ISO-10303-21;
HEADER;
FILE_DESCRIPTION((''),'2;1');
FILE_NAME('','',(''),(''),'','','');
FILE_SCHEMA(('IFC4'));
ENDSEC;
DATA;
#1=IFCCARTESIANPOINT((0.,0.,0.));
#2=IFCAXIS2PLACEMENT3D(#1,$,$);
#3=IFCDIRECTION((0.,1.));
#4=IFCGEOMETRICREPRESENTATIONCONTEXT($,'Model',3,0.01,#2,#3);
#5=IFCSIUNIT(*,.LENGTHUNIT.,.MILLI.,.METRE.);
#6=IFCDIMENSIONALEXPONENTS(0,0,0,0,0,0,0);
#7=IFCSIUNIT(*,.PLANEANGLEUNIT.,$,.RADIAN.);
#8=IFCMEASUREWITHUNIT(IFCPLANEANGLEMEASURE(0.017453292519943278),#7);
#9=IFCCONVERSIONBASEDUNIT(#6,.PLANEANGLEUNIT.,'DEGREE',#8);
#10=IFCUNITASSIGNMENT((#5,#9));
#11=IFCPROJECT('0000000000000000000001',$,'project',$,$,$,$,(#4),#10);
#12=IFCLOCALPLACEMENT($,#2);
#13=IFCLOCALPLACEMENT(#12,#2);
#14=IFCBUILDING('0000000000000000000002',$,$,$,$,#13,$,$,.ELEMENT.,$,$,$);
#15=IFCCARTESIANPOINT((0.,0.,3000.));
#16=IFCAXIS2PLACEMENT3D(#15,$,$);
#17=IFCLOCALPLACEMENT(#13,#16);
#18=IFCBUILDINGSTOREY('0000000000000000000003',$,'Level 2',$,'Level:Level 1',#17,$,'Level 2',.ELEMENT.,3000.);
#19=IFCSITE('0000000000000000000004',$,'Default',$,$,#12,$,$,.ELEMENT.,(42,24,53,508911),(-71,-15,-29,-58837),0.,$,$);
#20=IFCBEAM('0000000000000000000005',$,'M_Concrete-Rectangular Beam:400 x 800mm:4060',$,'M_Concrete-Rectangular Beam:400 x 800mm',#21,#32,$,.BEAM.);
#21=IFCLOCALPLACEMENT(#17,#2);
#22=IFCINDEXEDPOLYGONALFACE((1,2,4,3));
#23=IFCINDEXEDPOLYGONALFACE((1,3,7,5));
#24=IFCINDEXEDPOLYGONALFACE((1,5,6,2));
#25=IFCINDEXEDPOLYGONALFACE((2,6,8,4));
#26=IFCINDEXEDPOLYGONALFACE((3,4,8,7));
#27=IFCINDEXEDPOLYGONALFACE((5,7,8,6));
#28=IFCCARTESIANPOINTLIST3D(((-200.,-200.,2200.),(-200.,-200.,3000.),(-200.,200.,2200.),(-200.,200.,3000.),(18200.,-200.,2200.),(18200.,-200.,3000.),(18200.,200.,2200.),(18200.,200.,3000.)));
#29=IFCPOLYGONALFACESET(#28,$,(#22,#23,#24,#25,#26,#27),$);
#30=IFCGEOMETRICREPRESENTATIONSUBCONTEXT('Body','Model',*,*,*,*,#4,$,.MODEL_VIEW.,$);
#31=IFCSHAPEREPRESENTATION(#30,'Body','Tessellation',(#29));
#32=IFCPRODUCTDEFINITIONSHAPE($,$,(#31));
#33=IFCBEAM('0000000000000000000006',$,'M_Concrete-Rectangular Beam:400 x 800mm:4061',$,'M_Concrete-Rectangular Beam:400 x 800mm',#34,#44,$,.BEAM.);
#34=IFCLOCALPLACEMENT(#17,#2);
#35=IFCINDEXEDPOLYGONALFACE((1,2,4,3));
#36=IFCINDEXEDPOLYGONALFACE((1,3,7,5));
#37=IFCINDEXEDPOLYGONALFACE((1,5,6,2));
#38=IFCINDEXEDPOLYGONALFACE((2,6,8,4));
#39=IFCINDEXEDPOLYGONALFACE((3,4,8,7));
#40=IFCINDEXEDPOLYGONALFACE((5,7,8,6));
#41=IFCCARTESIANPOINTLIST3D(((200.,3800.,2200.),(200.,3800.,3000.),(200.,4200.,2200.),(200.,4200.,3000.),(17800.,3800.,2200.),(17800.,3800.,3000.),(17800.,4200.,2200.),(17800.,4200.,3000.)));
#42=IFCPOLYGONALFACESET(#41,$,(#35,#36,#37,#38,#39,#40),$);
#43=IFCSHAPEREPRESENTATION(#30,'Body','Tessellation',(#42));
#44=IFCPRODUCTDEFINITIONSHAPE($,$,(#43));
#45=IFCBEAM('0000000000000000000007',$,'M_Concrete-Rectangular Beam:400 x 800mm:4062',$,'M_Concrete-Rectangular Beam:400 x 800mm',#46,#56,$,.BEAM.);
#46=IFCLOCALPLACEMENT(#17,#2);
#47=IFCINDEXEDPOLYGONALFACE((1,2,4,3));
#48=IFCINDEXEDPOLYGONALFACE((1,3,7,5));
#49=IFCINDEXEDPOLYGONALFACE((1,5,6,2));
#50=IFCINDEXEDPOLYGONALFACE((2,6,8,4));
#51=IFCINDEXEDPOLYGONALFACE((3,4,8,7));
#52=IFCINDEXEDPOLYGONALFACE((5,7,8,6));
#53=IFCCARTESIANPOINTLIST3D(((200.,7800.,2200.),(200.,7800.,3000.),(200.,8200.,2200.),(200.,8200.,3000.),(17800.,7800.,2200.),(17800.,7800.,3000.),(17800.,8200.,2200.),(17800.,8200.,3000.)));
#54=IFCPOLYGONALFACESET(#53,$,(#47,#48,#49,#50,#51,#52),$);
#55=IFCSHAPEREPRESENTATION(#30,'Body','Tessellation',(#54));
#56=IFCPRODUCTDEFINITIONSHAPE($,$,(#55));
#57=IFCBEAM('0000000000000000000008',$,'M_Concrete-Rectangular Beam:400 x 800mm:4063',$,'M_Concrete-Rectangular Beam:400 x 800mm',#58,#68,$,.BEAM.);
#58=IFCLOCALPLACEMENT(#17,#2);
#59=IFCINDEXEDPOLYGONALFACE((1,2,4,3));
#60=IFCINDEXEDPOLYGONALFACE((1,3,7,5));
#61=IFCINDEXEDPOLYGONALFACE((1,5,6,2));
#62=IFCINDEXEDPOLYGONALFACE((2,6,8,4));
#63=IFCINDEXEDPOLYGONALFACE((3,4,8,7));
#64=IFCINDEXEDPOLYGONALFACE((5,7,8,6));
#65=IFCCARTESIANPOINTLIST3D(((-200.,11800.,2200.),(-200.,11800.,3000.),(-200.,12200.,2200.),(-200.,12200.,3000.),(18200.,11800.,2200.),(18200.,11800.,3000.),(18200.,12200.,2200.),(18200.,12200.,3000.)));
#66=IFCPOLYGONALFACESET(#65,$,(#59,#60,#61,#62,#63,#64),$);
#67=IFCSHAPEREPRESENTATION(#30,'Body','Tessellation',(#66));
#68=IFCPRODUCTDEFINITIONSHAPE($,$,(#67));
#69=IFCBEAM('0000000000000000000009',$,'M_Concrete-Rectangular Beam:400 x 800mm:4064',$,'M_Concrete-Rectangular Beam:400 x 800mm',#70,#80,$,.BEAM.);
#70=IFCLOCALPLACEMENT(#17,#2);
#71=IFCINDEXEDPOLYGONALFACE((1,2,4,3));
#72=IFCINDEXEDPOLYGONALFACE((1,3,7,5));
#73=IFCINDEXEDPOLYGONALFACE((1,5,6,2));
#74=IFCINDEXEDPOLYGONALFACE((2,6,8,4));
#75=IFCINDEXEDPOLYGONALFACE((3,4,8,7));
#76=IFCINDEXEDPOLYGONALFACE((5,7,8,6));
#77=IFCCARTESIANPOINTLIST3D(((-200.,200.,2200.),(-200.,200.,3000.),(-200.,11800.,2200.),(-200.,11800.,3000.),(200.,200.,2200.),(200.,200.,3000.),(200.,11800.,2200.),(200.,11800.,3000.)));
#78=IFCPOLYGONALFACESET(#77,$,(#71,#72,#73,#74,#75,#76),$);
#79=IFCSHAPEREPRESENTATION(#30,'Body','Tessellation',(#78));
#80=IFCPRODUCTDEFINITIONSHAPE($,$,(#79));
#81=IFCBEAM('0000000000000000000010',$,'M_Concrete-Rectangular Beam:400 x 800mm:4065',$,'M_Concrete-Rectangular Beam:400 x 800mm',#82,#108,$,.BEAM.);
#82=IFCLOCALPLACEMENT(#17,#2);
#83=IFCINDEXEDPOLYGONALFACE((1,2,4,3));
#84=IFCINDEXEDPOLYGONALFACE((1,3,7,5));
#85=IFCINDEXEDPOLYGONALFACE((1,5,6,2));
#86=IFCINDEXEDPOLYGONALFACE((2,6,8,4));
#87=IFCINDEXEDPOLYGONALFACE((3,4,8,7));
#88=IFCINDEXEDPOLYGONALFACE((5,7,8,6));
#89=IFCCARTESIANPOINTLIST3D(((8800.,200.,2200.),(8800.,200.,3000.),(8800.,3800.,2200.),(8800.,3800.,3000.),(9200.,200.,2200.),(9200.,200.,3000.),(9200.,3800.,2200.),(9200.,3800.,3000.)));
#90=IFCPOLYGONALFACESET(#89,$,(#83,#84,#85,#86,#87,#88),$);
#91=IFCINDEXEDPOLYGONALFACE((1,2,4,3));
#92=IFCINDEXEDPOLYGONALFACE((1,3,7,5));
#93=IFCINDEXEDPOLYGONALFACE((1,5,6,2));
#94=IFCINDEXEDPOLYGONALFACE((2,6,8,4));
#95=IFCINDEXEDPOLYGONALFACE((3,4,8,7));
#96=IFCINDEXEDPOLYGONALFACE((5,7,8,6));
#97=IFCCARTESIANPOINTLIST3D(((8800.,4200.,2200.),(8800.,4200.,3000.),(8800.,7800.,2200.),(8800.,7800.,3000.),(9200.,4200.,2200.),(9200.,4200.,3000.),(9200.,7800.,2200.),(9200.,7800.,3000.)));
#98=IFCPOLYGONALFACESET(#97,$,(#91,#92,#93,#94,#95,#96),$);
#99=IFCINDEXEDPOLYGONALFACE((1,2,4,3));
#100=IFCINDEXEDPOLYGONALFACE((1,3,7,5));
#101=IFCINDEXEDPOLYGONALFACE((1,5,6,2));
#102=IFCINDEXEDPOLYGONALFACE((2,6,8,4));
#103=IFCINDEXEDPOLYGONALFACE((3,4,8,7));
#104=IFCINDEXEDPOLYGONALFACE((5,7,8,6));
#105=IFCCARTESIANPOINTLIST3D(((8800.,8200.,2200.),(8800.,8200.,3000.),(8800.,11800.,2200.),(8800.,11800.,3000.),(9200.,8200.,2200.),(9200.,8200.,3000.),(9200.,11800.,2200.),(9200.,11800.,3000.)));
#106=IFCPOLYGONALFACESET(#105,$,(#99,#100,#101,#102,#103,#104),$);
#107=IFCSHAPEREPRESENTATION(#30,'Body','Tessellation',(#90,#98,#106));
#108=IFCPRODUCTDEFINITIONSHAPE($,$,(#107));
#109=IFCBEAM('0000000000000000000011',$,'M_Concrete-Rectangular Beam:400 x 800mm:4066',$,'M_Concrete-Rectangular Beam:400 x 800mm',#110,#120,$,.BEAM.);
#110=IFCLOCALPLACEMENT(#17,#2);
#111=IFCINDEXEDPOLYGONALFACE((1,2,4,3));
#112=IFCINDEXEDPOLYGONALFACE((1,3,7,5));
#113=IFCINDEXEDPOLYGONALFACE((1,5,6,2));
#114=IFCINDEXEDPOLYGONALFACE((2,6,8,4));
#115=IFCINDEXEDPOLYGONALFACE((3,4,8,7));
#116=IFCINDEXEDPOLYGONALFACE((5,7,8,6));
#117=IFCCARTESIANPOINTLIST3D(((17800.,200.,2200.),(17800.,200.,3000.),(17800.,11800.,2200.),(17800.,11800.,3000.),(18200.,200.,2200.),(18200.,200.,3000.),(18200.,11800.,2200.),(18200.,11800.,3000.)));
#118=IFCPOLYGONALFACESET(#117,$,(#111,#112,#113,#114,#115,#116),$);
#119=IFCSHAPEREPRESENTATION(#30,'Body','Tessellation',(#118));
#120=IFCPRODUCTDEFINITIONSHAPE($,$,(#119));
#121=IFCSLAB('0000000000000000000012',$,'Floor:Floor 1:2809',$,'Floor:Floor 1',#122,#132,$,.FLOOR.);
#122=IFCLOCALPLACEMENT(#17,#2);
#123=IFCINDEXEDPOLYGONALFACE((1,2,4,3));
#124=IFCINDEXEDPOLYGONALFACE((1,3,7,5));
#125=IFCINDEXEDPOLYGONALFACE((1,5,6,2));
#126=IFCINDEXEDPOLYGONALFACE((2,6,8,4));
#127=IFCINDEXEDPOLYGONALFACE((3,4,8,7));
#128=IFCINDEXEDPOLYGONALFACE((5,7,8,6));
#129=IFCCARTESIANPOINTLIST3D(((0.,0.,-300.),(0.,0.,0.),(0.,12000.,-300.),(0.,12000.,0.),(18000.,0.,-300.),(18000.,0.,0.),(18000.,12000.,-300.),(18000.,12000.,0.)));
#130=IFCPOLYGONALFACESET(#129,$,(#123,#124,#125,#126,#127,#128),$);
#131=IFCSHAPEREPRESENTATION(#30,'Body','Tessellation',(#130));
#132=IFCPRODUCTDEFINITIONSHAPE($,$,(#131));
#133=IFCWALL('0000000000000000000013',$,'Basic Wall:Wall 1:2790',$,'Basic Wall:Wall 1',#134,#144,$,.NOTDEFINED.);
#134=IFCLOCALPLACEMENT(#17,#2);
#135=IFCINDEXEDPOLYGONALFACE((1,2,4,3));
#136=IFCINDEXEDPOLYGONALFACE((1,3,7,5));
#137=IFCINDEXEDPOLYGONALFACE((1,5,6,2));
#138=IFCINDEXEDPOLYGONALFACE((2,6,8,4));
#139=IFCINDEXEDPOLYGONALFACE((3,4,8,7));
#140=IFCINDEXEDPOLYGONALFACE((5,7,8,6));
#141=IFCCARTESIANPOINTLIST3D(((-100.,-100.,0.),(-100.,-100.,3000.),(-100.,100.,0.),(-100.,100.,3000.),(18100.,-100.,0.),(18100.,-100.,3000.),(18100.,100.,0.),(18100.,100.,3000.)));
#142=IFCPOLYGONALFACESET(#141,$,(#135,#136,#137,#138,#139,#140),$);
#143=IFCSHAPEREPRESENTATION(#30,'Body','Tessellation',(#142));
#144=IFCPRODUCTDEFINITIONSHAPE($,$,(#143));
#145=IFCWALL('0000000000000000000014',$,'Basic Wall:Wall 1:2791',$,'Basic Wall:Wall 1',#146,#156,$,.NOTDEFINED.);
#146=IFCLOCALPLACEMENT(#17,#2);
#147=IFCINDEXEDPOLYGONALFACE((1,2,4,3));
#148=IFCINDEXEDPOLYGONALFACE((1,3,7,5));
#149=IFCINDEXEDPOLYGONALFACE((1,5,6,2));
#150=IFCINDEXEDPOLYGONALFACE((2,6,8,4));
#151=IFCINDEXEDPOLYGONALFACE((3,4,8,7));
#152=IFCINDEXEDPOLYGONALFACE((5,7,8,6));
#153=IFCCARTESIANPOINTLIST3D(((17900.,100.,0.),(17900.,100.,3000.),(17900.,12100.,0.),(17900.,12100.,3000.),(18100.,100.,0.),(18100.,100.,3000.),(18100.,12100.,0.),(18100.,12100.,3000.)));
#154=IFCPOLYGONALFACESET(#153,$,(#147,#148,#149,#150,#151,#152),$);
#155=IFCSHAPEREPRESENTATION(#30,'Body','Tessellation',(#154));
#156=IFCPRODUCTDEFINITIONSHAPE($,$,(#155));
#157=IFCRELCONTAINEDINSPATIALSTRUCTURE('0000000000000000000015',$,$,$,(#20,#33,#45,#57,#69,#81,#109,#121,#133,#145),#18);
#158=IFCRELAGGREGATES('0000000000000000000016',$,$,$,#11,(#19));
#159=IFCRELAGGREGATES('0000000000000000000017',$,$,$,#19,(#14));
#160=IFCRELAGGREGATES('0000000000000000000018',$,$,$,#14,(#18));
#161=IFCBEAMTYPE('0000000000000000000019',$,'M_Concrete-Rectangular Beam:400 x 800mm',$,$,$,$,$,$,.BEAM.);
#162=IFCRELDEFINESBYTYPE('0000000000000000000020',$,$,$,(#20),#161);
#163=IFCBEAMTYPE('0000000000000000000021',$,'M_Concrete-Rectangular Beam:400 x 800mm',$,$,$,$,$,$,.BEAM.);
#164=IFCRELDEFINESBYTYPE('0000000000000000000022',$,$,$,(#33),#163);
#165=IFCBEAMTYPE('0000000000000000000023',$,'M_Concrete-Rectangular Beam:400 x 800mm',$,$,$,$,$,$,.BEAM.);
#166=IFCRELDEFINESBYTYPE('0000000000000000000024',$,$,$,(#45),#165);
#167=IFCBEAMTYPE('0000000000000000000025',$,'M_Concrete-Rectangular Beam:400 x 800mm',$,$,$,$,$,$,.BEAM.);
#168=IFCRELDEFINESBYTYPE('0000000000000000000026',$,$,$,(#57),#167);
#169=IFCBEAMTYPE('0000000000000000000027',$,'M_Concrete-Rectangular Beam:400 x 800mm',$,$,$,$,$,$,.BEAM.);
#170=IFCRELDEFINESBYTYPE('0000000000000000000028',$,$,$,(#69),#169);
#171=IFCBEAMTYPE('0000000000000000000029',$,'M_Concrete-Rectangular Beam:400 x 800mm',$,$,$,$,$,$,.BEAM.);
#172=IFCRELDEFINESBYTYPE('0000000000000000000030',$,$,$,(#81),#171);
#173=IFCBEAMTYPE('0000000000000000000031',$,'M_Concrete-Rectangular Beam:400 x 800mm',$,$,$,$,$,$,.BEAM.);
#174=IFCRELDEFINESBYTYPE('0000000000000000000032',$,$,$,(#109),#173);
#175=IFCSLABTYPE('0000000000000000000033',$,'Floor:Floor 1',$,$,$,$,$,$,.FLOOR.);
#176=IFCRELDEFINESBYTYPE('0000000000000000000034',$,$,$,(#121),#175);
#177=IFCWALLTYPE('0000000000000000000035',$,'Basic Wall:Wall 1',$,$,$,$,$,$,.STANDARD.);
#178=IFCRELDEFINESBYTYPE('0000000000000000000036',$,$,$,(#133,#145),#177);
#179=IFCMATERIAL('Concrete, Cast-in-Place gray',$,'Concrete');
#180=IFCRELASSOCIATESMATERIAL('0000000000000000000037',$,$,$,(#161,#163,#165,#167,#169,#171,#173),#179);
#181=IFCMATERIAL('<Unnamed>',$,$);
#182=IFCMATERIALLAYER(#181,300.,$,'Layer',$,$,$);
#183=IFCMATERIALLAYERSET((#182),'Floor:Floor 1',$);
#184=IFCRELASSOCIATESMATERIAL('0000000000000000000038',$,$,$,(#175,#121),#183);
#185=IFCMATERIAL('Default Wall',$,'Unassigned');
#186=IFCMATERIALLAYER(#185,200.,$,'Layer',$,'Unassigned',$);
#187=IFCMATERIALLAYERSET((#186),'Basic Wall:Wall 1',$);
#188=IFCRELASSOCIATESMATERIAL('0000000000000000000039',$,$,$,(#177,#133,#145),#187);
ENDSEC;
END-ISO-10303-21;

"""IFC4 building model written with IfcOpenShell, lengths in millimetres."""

from ifc_helpers import new_model, entity, si_unit, converted_unit, direction, frame, frame_2d, origin, origin_2d_with_axis, place, context, subcontext, project, spatial, rectangle, extrude, source, transform, mapped, material, layer, layer_set, layer_usage, material_profile, profile_set, type_object, type_shapes, element, save


model = new_model("IFC4")

# Units and contexts
model_context = context("Model", 3, precision=0.01, world=origin(), true_north=direction((0.0, 1.0)))
body_context = subcontext(model_context, "Body", "Model", "MODEL_VIEW")
ifc_project = project(units=[si_unit("LENGTHUNIT", "METRE", prefix="MILLI"), converted_unit("PLANEANGLEUNIT", "DEGREE", entity("IfcPlaneAngleMeasure", 0.017453292519943278), si_unit("PLANEANGLEUNIT", "RADIAN"), dimensions=[0, 0, 0, 0, 0, 0, 0])], contexts=[model_context])

# Site, building, storey
site_placement = place(None, origin())
site = spatial("IfcSite", under=ifc_project, at=site_placement, Name="Default", CompositionType="ELEMENT", RefLatitude=(42, 24, 53, 508911), RefLongitude=(-71, -15, -29, -58837), RefElevation=0.0)
building_placement = place(site_placement, origin())
building = spatial("IfcBuilding", under=site, at=building_placement, CompositionType="ELEMENT")
storey_placement = place(building_placement, frame((0.0, 0.0, 3000.0)))
storey = spatial("IfcBuildingStorey", under=building, at=storey_placement, Name="Level 2", ObjectType="Level:Level 1", LongName="Level 2", CompositionType="ELEMENT", Elevation=3000.0)

# Beams
ifc_material_1 = material(Name="Concrete, Cast-in-Place gray", Category="Concrete")
ifc_material_profile = material_profile(ifc_material_1, rectangle(XDim=800.0, YDim=400.0, at=origin_2d_with_axis()), Name="400 x 800mm")
ifc_profile_set = profile_set([ifc_material_profile], Name="400 x 800mm")
beam_type_1 = type_object("IfcBeamType", Name="M_Concrete-Rectangular Beam:400 x 800mm", PredefinedType="BEAM", material=ifc_profile_set)
shared_shape_1 = source(origin(), body_context, "Body", "SweptSolid", [
    extrude(rectangle(XDim=800.0, YDim=400.0, at=origin_2d_with_axis()), frame((-200.0, 0.0, 5600.0), z_axis=(1.0, 0.0, 0.0), x_axis=(0.0, 0.0, -1.0)), (0.0, 0.0, 1.0), 18400.0),
])
type_shapes(beam_type_1, [shared_shape_1])
beam_1_placement = place(storey_placement, frame((0.0, 0.0, -3000.0)))
element("IfcBeam", 1, at=beam_1_placement, inside=storey, type_object=beam_type_1, Name="M_Concrete-Rectangular Beam:400 x 800mm:4060", ObjectType="M_Concrete-Rectangular Beam:400 x 800mm", PredefinedType="BEAM", context=body_context, shape_type="MappedRepresentation", body=[
    mapped(shared_shape_1, transform((0.0, 0.0, 0.0), scale=1.0)),
])
beam_type_2 = type_object("IfcBeamType", Name="M_Concrete-Rectangular Beam:400 x 800mm", PredefinedType="BEAM", material=ifc_profile_set)
shared_shape_2 = source(origin(), body_context, "Body", "SweptSolid", [
    extrude(rectangle(XDim=800.0, YDim=400.0, at=origin_2d_with_axis()), frame((200.0, 4000.0, 5600.0), z_axis=(1.0, 0.0, 0.0), x_axis=(0.0, 0.0, -1.0)), (0.0, 0.0, 1.0), 17600.0),
])
type_shapes(beam_type_2, [shared_shape_2])
beam_2_placement = place(storey_placement, frame((0.0, 0.0, -3000.0)))
element("IfcBeam", 2, at=beam_2_placement, inside=storey, type_object=beam_type_2, Name="M_Concrete-Rectangular Beam:400 x 800mm:4061", ObjectType="M_Concrete-Rectangular Beam:400 x 800mm", PredefinedType="BEAM", context=body_context, shape_type="MappedRepresentation", body=[
    mapped(shared_shape_2, transform((0.0, 0.0, 0.0), scale=1.0)),
])
beam_type_3 = type_object("IfcBeamType", Name="M_Concrete-Rectangular Beam:400 x 800mm", PredefinedType="BEAM", material=ifc_profile_set)
shared_shape_3 = source(origin(), body_context, "Body", "SweptSolid", [
    extrude(rectangle(XDim=800.0, YDim=400.0, at=frame_2d((0.0, 0.0), x_axis=(1.0, 0.0))), frame((200.0, 8000.0, 5600.0), z_axis=(1.0, 0.0, 0.0), x_axis=(0.0, 0.0, -1.0)), (0.0, 0.0, 1.0), 17600.0),
])
type_shapes(beam_type_3, [shared_shape_3])
beam_3_placement = place(storey_placement, frame((0.0, 0.0, -3000.0)))
element("IfcBeam", 3, at=beam_3_placement, inside=storey, type_object=beam_type_3, Name="M_Concrete-Rectangular Beam:400 x 800mm:4062", ObjectType="M_Concrete-Rectangular Beam:400 x 800mm", PredefinedType="BEAM", context=body_context, shape_type="MappedRepresentation", body=[
    mapped(shared_shape_3, transform((0.0, 0.0, 0.0), scale=1.0)),
])
beam_type_4 = type_object("IfcBeamType", Name="M_Concrete-Rectangular Beam:400 x 800mm", PredefinedType="BEAM", material=ifc_profile_set)
shared_shape_4 = source(origin(), body_context, "Body", "SweptSolid", [
    extrude(rectangle(XDim=800.0, YDim=400.0, at=frame_2d((0.0, 0.0), x_axis=(1.0, 0.0))), frame((-200.0, 12000.0, 5600.0), z_axis=(1.0, 0.0, 0.0), x_axis=(0.0, 0.0, -1.0)), (0.0, 0.0, 1.0), 18400.0),
])
type_shapes(beam_type_4, [shared_shape_4])
beam_4_placement = place(storey_placement, frame((0.0, 0.0, -3000.0)))
element("IfcBeam", 4, at=beam_4_placement, inside=storey, type_object=beam_type_4, Name="M_Concrete-Rectangular Beam:400 x 800mm:4063", ObjectType="M_Concrete-Rectangular Beam:400 x 800mm", PredefinedType="BEAM", context=body_context, shape_type="MappedRepresentation", body=[
    mapped(shared_shape_4, transform((0.0, 0.0, 0.0), scale=1.0)),
])
beam_type_5 = type_object("IfcBeamType", Name="M_Concrete-Rectangular Beam:400 x 800mm", PredefinedType="BEAM", material=ifc_profile_set)
shared_shape_5 = source(origin(), body_context, "Body", "SweptSolid", [
    extrude(rectangle(XDim=800.0, YDim=400.0, at=frame_2d((0.0, 0.0), x_axis=(0.0, 1.0))), frame((0.0, 200.0, 5600.0), z_axis=(0.0, 1.0, 0.0), x_axis=(-1.0, 0.0, 0.0)), (0.0, 0.0, 1.0), 11600.0),
])
type_shapes(beam_type_5, [shared_shape_5])
beam_5_placement = place(storey_placement, frame((0.0, 0.0, -3000.0)))
element("IfcBeam", 5, at=beam_5_placement, inside=storey, type_object=beam_type_5, Name="M_Concrete-Rectangular Beam:400 x 800mm:4064", ObjectType="M_Concrete-Rectangular Beam:400 x 800mm", PredefinedType="BEAM", context=body_context, shape_type="MappedRepresentation", body=[
    mapped(shared_shape_5, transform((0.0, 0.0, 0.0), scale=1.0)),
])
beam_type_6 = type_object("IfcBeamType", Name="M_Concrete-Rectangular Beam:400 x 800mm", PredefinedType="BEAM", material=ifc_profile_set)
shared_shape_6 = source(origin(), body_context, "Body", "SweptSolid", [
    extrude(rectangle(XDim=800.0, YDim=400.0, at=frame_2d((0.0, 0.0), x_axis=(0.0, 1.0))), frame((9000.0, 200.0, 5600.0), z_axis=(0.0, 1.0, 0.0), x_axis=(-1.0, 0.0, 0.0)), (0.0, 0.0, 1.0), 3600.0),
    extrude(rectangle(XDim=800.0, YDim=400.0, at=frame_2d((0.0, 0.0), x_axis=(0.0, 1.0))), frame((9000.0, 4200.0, 5600.0), z_axis=(0.0, 1.0, 0.0), x_axis=(-1.0, 0.0, 0.0)), (0.0, 0.0, 1.0), 3600.0),
    extrude(rectangle(XDim=800.0, YDim=400.0, at=frame_2d((0.0, 0.0), x_axis=(0.0, 1.0))), frame((9000.0, 8200.0, 5600.0), z_axis=(0.0, 1.0, 0.0), x_axis=(-1.0, 0.0, 0.0)), (0.0, 0.0, 1.0), 3600.0),
])
type_shapes(beam_type_6, [shared_shape_6])
beam_6_placement = place(storey_placement, frame((0.0, 0.0, -3000.0)))
element("IfcBeam", 6, at=beam_6_placement, inside=storey, type_object=beam_type_6, Name="M_Concrete-Rectangular Beam:400 x 800mm:4065", ObjectType="M_Concrete-Rectangular Beam:400 x 800mm", PredefinedType="BEAM", context=body_context, shape_type="MappedRepresentation", body=[
    mapped(shared_shape_6, transform((0.0, 0.0, 0.0), scale=1.0)),
])
beam_type_7 = type_object("IfcBeamType", Name="M_Concrete-Rectangular Beam:400 x 800mm", PredefinedType="BEAM", material=ifc_profile_set)
shared_shape_7 = source(origin(), body_context, "Body", "SweptSolid", [
    extrude(rectangle(XDim=800.0, YDim=400.0, at=frame_2d((0.0, 0.0), x_axis=(0.0, 1.0))), frame((18000.0, 200.0, 5600.0), z_axis=(0.0, 1.0, 0.0), x_axis=(-1.0, 0.0, 0.0)), (0.0, 0.0, 1.0), 11600.0),
])
type_shapes(beam_type_7, [shared_shape_7])
beam_7_placement = place(storey_placement, frame((0.0, 0.0, -3000.0)))
element("IfcBeam", 7, at=beam_7_placement, inside=storey, type_object=beam_type_7, Name="M_Concrete-Rectangular Beam:400 x 800mm:4066", ObjectType="M_Concrete-Rectangular Beam:400 x 800mm", PredefinedType="BEAM", context=body_context, shape_type="MappedRepresentation", body=[
    mapped(shared_shape_7, transform((0.0, 0.0, 0.0), scale=1.0)),
])

# Slab
ifc_material_2 = material(Name="<Unnamed>")
ifc_layer_1 = layer(ifc_material_2, 300.0, Name="Layer")
ifc_layer_set_1 = layer_set([ifc_layer_1], Name="Floor:Floor 1")
ifc_layer_usage_1 = layer_usage(ifc_layer_set_1, "AXIS3", "POSITIVE", 0.0)
slab_type = type_object("IfcSlabType", Name="Floor:Floor 1", PredefinedType="FLOOR", material=ifc_layer_set_1)
slab_placement = place(storey_placement, origin())
element("IfcSlab", 8, at=slab_placement, inside=storey, type_object=slab_type, material=ifc_layer_usage_1, Name="Floor:Floor 1:2809", ObjectType="Floor:Floor 1", PredefinedType="FLOOR", context=body_context, shape_type="SweptSolid", body=[
    extrude(rectangle(XDim=12000.0, YDim=18000.0, at=origin_2d_with_axis()), frame((9000.0, 6000.0, 0.0), z_axis=(0.0, 0.0, -1.0), x_axis=(0.0, 1.0, 0.0)), (0.0, 0.0, 1.0), 300.0),
])

# Walls
ifc_material_3 = material(Name="Default Wall", Category="Unassigned")
ifc_layer_2 = layer(ifc_material_3, 200.0, Name="Layer", Category="Unassigned")
ifc_layer_set_2 = layer_set([ifc_layer_2], Name="Basic Wall:Wall 1")
ifc_layer_usage_2 = layer_usage(ifc_layer_set_2, "AXIS2", "NEGATIVE", 100.0)
wall_type = type_object("IfcWallType", Name="Basic Wall:Wall 1", PredefinedType="STANDARD", material=ifc_layer_set_2)
wall_1_placement = place(storey_placement, frame((-100.0, 0.0, 0.0)))
element("IfcWall", 9, at=wall_1_placement, inside=storey, type_object=wall_type, material=ifc_layer_usage_2, Name="Basic Wall:Wall 1:2790", ObjectType="Basic Wall:Wall 1", PredefinedType="NOTDEFINED", context=body_context, shape_type="SweptSolid", body=[
    extrude(rectangle(XDim=18200.0, YDim=200.0, at=frame_2d((9100.0, 0.0), x_axis=(-1.0, 0.0))), origin(), (0.0, 0.0, 1.0), 3000.0),
])
ifc_layer_usage_3 = layer_usage(ifc_layer_set_2, "AXIS2", "NEGATIVE", 100.0)
wall_2_placement = place(storey_placement, frame((18000.0, 100.0, 0.0), z_axis=(0.0, 0.0, 1.0), x_axis=(0.0, 1.0, 0.0)))
element("IfcWall", 10, at=wall_2_placement, inside=storey, type_object=wall_type, material=ifc_layer_usage_3, Name="Basic Wall:Wall 1:2791", ObjectType="Basic Wall:Wall 1", PredefinedType="NOTDEFINED", context=body_context, shape_type="SweptSolid", body=[
    extrude(rectangle(XDim=12000.0, YDim=200.0, at=frame_2d((6000.0, 0.0), x_axis=(-1.0, 0.0))), origin(), (0.0, 0.0, 1.0), 3000.0),
])

save(model, "model.ifc")
